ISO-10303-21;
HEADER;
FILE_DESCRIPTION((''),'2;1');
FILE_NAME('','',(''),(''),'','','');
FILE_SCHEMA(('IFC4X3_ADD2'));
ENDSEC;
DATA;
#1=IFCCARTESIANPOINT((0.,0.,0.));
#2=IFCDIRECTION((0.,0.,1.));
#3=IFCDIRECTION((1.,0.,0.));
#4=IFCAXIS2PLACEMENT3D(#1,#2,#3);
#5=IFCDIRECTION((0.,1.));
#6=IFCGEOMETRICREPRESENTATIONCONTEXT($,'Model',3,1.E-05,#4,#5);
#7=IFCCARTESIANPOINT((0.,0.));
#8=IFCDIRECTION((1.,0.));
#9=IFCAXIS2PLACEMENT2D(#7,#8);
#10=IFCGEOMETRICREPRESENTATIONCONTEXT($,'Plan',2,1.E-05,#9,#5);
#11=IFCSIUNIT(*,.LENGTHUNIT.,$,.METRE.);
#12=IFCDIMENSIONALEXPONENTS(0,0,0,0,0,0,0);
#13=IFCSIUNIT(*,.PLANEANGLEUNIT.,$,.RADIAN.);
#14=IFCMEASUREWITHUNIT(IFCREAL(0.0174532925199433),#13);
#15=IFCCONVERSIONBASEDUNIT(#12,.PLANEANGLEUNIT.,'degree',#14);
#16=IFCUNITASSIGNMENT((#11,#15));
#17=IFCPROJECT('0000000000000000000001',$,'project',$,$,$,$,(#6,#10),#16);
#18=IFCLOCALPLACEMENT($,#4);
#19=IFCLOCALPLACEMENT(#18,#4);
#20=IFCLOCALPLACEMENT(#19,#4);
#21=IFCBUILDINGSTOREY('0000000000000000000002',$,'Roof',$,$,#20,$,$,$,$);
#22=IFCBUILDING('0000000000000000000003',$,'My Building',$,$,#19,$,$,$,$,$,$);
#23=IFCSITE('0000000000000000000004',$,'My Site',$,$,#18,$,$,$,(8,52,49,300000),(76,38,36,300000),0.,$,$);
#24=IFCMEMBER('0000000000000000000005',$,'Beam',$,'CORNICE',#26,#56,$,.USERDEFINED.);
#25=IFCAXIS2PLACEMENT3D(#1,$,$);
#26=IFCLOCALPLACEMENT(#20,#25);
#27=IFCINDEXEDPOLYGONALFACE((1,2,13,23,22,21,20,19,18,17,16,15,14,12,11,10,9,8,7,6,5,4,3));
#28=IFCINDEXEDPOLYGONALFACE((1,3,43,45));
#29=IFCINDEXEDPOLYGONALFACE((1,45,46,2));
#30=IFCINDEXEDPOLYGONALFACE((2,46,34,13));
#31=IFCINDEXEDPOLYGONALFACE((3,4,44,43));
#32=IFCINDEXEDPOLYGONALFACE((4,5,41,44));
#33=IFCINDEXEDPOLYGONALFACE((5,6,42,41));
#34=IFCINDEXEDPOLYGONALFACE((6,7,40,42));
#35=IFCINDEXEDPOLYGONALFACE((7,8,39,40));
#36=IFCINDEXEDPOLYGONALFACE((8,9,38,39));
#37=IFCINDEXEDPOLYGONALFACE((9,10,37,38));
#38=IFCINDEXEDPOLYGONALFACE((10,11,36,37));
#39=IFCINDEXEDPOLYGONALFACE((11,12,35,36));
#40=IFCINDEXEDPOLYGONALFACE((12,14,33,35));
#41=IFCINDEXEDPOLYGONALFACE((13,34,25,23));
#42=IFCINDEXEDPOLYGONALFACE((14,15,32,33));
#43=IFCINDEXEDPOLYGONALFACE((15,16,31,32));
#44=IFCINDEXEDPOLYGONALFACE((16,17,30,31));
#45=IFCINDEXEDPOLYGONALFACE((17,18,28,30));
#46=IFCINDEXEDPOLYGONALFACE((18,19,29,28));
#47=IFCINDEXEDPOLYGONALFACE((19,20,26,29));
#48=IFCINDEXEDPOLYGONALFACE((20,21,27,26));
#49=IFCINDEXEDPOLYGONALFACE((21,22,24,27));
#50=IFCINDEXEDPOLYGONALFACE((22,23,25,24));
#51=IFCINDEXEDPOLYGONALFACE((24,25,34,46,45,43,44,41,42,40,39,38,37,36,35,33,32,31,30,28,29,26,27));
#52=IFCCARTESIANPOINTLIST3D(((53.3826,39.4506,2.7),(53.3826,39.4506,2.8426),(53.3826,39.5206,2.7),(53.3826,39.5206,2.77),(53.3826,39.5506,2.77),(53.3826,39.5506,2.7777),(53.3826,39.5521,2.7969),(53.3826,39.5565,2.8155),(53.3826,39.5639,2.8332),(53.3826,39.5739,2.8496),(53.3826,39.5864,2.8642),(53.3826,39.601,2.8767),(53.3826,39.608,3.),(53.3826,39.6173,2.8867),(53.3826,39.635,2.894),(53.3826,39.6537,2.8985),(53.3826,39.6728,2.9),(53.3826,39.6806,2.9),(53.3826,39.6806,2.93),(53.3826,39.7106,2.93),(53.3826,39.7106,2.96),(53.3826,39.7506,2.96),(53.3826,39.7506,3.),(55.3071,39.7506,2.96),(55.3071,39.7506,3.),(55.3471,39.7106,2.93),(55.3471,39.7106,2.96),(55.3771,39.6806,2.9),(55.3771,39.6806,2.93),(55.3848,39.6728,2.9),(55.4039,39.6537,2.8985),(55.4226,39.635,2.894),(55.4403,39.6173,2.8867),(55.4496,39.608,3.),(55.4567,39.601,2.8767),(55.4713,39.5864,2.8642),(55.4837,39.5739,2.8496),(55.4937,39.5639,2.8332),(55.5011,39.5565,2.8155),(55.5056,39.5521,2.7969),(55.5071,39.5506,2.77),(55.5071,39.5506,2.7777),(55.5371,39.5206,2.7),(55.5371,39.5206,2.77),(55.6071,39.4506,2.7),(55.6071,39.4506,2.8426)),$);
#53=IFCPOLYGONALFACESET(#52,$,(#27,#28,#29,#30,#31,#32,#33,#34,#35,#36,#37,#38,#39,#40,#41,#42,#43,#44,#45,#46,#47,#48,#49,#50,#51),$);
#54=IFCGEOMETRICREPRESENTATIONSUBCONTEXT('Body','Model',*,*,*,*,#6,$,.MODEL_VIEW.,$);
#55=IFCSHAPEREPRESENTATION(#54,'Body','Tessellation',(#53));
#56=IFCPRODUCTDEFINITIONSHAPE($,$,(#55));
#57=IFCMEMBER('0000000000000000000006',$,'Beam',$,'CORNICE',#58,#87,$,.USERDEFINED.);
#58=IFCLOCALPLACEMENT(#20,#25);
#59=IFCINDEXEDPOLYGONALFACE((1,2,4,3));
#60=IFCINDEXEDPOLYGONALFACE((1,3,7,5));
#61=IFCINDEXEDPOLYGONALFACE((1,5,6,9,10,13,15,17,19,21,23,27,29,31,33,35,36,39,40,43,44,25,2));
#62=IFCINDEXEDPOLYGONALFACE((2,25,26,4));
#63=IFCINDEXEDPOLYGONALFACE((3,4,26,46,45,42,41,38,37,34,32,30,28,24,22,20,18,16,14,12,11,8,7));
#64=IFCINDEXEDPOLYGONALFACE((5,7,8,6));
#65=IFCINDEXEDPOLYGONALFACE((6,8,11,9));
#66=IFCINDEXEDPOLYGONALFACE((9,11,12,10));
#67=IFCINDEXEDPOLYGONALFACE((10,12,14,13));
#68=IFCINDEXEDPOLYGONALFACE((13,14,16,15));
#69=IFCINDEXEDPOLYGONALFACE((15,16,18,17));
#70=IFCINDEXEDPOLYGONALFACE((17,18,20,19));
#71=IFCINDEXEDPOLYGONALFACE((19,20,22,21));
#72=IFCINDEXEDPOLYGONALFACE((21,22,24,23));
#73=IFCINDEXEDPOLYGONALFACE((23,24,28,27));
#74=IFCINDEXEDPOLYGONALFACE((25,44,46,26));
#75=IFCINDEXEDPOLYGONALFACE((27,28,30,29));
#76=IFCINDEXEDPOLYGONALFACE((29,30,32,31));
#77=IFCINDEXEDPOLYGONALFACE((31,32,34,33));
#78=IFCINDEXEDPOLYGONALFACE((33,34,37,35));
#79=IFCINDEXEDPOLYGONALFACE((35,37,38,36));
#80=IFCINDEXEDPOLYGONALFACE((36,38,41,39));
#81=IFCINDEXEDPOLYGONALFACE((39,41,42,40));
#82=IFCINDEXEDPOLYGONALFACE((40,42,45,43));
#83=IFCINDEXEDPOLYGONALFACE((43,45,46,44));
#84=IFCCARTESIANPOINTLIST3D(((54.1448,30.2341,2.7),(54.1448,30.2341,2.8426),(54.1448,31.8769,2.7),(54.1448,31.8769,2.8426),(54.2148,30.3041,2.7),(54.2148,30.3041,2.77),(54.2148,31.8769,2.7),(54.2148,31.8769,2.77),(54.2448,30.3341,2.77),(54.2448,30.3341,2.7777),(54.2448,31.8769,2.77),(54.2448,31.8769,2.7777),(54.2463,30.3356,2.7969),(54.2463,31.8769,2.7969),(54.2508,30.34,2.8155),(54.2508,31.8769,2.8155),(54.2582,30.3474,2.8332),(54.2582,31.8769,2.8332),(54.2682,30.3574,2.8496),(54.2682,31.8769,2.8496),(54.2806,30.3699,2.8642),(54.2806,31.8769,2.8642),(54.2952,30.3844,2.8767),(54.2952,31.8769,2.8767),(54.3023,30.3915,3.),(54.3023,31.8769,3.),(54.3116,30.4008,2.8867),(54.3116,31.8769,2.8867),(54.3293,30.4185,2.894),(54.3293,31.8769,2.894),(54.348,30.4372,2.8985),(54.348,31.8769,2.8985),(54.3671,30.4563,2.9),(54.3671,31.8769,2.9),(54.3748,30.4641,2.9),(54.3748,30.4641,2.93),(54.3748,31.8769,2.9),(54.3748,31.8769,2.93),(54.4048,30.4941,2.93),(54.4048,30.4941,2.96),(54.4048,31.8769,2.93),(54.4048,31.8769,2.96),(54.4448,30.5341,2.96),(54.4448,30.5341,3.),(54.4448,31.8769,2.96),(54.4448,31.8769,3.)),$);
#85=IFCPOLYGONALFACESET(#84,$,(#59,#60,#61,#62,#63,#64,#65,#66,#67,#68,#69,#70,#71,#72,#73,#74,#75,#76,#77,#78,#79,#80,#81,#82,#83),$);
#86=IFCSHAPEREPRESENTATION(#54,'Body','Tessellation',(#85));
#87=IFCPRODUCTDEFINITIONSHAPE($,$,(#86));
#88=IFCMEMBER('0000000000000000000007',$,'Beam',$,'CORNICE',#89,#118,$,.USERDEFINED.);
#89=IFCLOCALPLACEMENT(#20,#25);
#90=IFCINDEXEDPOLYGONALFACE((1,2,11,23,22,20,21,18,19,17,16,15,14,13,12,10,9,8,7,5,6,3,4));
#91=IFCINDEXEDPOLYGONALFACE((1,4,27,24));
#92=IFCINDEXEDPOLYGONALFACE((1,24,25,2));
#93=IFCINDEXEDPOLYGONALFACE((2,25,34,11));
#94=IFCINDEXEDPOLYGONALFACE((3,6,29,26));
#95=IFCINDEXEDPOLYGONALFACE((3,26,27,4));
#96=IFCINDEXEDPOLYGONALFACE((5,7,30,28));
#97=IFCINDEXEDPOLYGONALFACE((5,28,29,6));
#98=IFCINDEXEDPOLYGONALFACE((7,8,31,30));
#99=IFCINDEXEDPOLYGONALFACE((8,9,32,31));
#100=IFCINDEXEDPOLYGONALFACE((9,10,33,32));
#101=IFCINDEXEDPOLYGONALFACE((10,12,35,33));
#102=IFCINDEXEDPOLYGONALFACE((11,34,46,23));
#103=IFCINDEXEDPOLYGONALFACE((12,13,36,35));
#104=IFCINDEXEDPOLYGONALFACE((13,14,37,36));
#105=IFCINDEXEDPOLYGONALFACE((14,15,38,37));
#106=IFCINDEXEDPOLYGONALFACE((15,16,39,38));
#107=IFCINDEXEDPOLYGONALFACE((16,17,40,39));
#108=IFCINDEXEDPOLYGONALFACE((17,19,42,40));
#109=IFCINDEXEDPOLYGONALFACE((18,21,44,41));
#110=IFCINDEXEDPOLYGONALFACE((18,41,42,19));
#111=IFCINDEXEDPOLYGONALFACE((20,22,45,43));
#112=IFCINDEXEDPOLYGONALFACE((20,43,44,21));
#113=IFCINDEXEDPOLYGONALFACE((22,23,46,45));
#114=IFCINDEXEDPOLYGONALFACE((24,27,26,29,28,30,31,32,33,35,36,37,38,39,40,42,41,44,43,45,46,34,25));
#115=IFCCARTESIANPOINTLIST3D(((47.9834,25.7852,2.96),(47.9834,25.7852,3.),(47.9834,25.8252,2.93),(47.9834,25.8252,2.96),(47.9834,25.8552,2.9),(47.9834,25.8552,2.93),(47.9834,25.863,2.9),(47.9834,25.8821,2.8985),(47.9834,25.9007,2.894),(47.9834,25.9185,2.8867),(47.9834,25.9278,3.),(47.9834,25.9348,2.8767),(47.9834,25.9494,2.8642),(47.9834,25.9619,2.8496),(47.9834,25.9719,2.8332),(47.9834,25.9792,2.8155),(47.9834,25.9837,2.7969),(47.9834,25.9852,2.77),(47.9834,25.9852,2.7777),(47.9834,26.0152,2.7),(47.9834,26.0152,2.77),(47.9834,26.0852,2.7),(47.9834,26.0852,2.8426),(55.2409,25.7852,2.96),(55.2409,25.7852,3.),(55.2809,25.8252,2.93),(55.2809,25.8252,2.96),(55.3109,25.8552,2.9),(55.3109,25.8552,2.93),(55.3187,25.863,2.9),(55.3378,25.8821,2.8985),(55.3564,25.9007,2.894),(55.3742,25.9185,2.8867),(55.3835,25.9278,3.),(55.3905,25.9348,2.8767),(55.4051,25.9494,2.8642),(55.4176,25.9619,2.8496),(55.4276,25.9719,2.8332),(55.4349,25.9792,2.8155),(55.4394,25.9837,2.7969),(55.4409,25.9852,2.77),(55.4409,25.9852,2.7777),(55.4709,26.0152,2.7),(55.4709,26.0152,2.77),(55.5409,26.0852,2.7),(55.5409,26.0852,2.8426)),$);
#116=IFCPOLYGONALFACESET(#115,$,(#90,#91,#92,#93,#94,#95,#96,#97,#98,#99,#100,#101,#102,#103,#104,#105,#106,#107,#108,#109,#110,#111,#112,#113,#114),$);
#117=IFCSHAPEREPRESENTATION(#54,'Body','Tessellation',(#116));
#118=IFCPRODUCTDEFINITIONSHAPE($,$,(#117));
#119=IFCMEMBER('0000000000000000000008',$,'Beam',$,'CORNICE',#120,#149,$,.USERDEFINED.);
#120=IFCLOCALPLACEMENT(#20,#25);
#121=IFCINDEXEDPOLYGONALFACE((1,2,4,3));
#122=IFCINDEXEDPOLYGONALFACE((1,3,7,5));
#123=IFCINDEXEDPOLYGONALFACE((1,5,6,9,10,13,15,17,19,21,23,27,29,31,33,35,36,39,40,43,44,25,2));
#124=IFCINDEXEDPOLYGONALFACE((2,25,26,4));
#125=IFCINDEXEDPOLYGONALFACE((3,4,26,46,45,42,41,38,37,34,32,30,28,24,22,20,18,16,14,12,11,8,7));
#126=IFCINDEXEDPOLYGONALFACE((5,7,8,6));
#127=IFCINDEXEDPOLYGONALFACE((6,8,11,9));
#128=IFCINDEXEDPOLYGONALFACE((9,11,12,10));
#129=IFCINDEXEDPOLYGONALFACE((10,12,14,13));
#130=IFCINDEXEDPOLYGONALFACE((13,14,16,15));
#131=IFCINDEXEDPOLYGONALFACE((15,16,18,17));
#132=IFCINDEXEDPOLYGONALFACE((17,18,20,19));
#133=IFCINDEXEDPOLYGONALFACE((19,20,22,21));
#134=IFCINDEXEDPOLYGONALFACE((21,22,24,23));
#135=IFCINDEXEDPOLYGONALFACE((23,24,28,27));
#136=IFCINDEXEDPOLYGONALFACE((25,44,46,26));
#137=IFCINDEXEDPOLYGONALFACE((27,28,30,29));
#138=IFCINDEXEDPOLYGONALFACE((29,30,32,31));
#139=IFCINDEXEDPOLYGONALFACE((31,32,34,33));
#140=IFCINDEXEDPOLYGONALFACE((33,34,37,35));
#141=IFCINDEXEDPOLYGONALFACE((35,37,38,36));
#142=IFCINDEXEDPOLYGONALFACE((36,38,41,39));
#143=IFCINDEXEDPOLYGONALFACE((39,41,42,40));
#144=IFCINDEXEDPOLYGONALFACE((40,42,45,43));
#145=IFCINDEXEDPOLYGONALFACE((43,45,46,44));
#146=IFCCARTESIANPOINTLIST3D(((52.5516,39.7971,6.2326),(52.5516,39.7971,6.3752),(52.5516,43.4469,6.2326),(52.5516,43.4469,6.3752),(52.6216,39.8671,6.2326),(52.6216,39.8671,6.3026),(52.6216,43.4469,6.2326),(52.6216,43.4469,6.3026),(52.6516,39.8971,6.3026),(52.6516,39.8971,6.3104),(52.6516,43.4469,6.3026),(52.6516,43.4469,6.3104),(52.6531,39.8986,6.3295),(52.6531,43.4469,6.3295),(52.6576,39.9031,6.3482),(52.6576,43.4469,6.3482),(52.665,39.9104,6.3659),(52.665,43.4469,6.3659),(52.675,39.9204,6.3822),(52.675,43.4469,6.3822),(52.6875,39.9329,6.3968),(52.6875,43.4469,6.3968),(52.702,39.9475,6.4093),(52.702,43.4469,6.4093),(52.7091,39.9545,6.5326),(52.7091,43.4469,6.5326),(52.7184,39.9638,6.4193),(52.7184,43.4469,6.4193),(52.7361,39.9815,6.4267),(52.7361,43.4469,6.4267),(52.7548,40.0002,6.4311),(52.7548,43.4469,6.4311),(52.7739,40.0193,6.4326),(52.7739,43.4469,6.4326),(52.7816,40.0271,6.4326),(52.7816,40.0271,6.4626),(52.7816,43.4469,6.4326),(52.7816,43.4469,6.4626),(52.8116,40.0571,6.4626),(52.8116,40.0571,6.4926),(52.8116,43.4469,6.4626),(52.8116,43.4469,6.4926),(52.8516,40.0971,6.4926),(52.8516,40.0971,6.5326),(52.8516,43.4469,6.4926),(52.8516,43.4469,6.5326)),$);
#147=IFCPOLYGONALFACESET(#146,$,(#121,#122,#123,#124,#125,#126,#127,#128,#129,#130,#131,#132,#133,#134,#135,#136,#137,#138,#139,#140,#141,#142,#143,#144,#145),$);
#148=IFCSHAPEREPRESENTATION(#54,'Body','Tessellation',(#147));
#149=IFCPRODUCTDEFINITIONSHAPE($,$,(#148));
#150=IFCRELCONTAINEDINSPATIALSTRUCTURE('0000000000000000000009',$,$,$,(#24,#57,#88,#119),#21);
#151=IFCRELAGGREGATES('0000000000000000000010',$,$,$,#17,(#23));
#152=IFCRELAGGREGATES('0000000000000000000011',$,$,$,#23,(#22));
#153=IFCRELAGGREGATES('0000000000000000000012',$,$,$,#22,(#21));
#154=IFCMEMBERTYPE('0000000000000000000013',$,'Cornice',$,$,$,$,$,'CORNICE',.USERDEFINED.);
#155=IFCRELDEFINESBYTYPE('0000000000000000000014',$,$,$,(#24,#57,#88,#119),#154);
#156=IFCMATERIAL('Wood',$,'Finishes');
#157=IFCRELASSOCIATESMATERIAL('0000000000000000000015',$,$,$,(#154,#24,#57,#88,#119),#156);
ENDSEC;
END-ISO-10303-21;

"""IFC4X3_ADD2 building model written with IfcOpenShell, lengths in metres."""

from ifc_helpers import new_model, entity, si_unit, converted_unit, direction, frame, origin_with_axes, origin_2d_with_axis, place, context, subcontext, project, spatial, indexed_curve, outline, extrude, clip, halfspace, material, material_profile, profile_set, profile_usage, type_object, element, save


model = new_model("IFC4X3_ADD2")

# Units and contexts
model_context = context("Model", 3, precision=1e-05, world=origin_with_axes(), true_north=direction((0.0, 1.0)))
plan_context = context("Plan", 2, precision=1e-05, world=origin_2d_with_axis(), true_north=direction((0.0, 1.0)))
body_context = subcontext(model_context, "Body", "Model", "MODEL_VIEW")
ifc_project = project(units=[si_unit("LENGTHUNIT", "METRE"), converted_unit("PLANEANGLEUNIT", "degree", entity("IfcReal", 0.0174532925199433), si_unit("PLANEANGLEUNIT", "RADIAN"), dimensions=[0, 0, 0, 0, 0, 0, 0])], contexts=[model_context, plan_context])

# Site, building, storey
site_placement = place(None, origin_with_axes())
site = spatial("IfcSite", under=ifc_project, at=site_placement, Name="My Site", RefLatitude=(8, 52, 49, 300000), RefLongitude=(76, 38, 36, 300000), RefElevation=0.0)
building_placement = place(site_placement, origin_with_axes())
building = spatial("IfcBuilding", under=site, at=building_placement, Name="My Building")
storey_placement = place(building_placement, origin_with_axes())
storey = spatial("IfcBuildingStorey", under=building, at=storey_placement, Name="Roof")

# Members
ifc_material_1 = material(Name="Wood", Category="Finishes")
ifc_material_profile_1 = material_profile(ifc_material_1, outline(indexed_curve([(-0.26, 0.26), (-0.3, 0.26), (-0.3, 0.3), (-0.1574, 0.3), (0.0, 0.1426), (0.0, 0.0), (-0.07, 0.0), (-0.07, 0.07), (-0.1, 0.07), (-0.1, 0.0777), (-0.1015, 0.0969), (-0.106, 0.1155), (-0.1133, 0.1332), (-0.1233, 0.1496), (-0.1358, 0.1642), (-0.1504, 0.1767), (-0.1668, 0.1867), (-0.1845, 0.194), (-0.2031, 0.1985), (-0.2223, 0.2), (-0.23, 0.2), (-0.23, 0.23), (-0.26, 0.23), (-0.26, 0.26)])))
ifc_profile_set_1 = profile_set([ifc_material_profile_1])
member_type = type_object("IfcMemberType", Name="Cornice", ElementType="CORNICE", PredefinedType="USERDEFINED", material=ifc_profile_set_1)
ifc_profile_usage_1 = profile_usage(ifc_profile_set_1, cardinal=5)
member_1_placement = place(storey_placement, frame((55.6071, 39.4506, 2.7), z_axis=(-1.0, 0.0, 0.0), x_axis=(0.0, -1.0, 0.0)))
element("IfcMember", 1, at=member_1_placement, inside=storey, type_object=member_type, material=ifc_profile_usage_1, Name="Beam", ObjectType="CORNICE", PredefinedType="USERDEFINED", context=body_context, shape_type="Clipping", body=[
    clip(extrude(outline(indexed_curve([(-0.26, 0.26), (-0.3, 0.26), (-0.3, 0.3), (-0.1574, 0.3), (0.0, 0.1426), (0.0, 0.0), (-0.07, 0.0), (-0.07, 0.07), (-0.1, 0.07), (-0.1, 0.0777), (-0.1015, 0.0969), (-0.106, 0.1155), (-0.1133, 0.1332), (-0.1233, 0.1496), (-0.1358, 0.1642), (-0.1504, 0.1767), (-0.1668, 0.1867), (-0.1845, 0.194), (-0.2031, 0.1985), (-0.2223, 0.2), (-0.23, 0.2), (-0.23, 0.23), (-0.26, 0.23), (-0.26, 0.26)])), origin_with_axes(), (0.0, 0.0, 1.0), 2.2245), halfspace(frame((0.0, -2.7, 0.0), z_axis=(-0.707107, 0.0, -0.707107), x_axis=(0.0, 1.0, 0.0)), False)),
])
ifc_profile_usage_2 = profile_usage(ifc_profile_set_1, cardinal=5)
member_2_placement = place(storey_placement, frame((54.1448, 30.2341, 2.7), z_axis=(0.0, 1.0, 0.0), x_axis=(-1.0, 0.0, 0.0)))
element("IfcMember", 2, at=member_2_placement, inside=storey, type_object=member_type, material=ifc_profile_usage_2, Name="Beam", ObjectType="CORNICE", PredefinedType="USERDEFINED", context=body_context, shape_type="Clipping", body=[
    clip(extrude(outline(indexed_curve([(-0.26, 0.26), (-0.3, 0.26), (-0.3, 0.3), (-0.1574, 0.3), (0.0, 0.1426), (0.0, 0.0), (-0.07, 0.0), (-0.07, 0.07), (-0.1, 0.07), (-0.1, 0.0777), (-0.1015, 0.0969), (-0.106, 0.1155), (-0.1133, 0.1332), (-0.1233, 0.1496), (-0.1358, 0.1642), (-0.1504, 0.1767), (-0.1668, 0.1867), (-0.1845, 0.194), (-0.2031, 0.1985), (-0.2223, 0.2), (-0.23, 0.2), (-0.23, 0.23), (-0.26, 0.23), (-0.26, 0.26)])), origin_with_axes(), (0.0, 0.0, 1.0), 1.6429), halfspace(frame((0.0, -2.7, 0.0), z_axis=(-0.707107, 0.0, -0.707107), x_axis=(0.0, 1.0, 0.0)), False)),
])
ifc_profile_usage_3 = profile_usage(ifc_profile_set_1, cardinal=5)
member_3_placement = place(storey_placement, frame((47.9834, 26.0852, 2.7), z_axis=(1.0, 0.0, 0.0), x_axis=(0.0, 1.0, 0.0)))
element("IfcMember", 3, at=member_3_placement, inside=storey, type_object=member_type, material=ifc_profile_usage_3, Name="Beam", ObjectType="CORNICE", PredefinedType="USERDEFINED", context=body_context, shape_type="Clipping", body=[
    clip(extrude(outline(indexed_curve([(-0.26, 0.26), (-0.3, 0.26), (-0.3, 0.3), (-0.1574, 0.3), (0.0, 0.1426), (0.0, 0.0), (-0.07, 0.0), (-0.07, 0.07), (-0.1, 0.07), (-0.1, 0.0777), (-0.1015, 0.0969), (-0.106, 0.1155), (-0.1133, 0.1332), (-0.1233, 0.1496), (-0.1358, 0.1642), (-0.1504, 0.1767), (-0.1668, 0.1867), (-0.1845, 0.194), (-0.2031, 0.1985), (-0.2223, 0.2), (-0.23, 0.2), (-0.23, 0.23), (-0.26, 0.23), (-0.26, 0.26)])), origin_with_axes(), (0.0, 0.0, 1.0), 7.5576), halfspace(frame((0.0, -2.7, 7.5576), z_axis=(-0.707107, 0.0, 0.707107), x_axis=(0.0, 1.0, 0.0)), False)),
])
ifc_profile_usage_4 = profile_usage(ifc_profile_set_1, cardinal=5)
member_4_placement = place(storey_placement, frame((52.5516, 39.7971, 6.2326), z_axis=(0.0, 1.0, 0.0), x_axis=(-1.0, 0.0, 0.0)))
element("IfcMember", 4, at=member_4_placement, inside=storey, type_object=member_type, material=ifc_profile_usage_4, Name="Beam", ObjectType="CORNICE", PredefinedType="USERDEFINED", context=body_context, shape_type="Clipping", body=[
    clip(extrude(outline(indexed_curve([(-0.26, 0.26), (-0.3, 0.26), (-0.3, 0.3), (-0.1574, 0.3), (0.0, 0.1426), (0.0, 0.0), (-0.07, 0.0), (-0.07, 0.07), (-0.1, 0.07), (-0.1, 0.0777), (-0.1015, 0.0969), (-0.106, 0.1155), (-0.1133, 0.1332), (-0.1233, 0.1496), (-0.1358, 0.1642), (-0.1504, 0.1767), (-0.1668, 0.1867), (-0.1845, 0.194), (-0.2031, 0.1985), (-0.2223, 0.2), (-0.23, 0.2), (-0.23, 0.23), (-0.26, 0.23), (-0.26, 0.26)])), origin_with_axes(), (0.0, 0.0, 1.0), 3.6498), halfspace(frame((0.0, -6.1726, 0.0), z_axis=(-0.707107, 0.0, -0.707107), x_axis=(0.0, 1.0, 0.0)), False)),
])

save(model, "model.ifc")
